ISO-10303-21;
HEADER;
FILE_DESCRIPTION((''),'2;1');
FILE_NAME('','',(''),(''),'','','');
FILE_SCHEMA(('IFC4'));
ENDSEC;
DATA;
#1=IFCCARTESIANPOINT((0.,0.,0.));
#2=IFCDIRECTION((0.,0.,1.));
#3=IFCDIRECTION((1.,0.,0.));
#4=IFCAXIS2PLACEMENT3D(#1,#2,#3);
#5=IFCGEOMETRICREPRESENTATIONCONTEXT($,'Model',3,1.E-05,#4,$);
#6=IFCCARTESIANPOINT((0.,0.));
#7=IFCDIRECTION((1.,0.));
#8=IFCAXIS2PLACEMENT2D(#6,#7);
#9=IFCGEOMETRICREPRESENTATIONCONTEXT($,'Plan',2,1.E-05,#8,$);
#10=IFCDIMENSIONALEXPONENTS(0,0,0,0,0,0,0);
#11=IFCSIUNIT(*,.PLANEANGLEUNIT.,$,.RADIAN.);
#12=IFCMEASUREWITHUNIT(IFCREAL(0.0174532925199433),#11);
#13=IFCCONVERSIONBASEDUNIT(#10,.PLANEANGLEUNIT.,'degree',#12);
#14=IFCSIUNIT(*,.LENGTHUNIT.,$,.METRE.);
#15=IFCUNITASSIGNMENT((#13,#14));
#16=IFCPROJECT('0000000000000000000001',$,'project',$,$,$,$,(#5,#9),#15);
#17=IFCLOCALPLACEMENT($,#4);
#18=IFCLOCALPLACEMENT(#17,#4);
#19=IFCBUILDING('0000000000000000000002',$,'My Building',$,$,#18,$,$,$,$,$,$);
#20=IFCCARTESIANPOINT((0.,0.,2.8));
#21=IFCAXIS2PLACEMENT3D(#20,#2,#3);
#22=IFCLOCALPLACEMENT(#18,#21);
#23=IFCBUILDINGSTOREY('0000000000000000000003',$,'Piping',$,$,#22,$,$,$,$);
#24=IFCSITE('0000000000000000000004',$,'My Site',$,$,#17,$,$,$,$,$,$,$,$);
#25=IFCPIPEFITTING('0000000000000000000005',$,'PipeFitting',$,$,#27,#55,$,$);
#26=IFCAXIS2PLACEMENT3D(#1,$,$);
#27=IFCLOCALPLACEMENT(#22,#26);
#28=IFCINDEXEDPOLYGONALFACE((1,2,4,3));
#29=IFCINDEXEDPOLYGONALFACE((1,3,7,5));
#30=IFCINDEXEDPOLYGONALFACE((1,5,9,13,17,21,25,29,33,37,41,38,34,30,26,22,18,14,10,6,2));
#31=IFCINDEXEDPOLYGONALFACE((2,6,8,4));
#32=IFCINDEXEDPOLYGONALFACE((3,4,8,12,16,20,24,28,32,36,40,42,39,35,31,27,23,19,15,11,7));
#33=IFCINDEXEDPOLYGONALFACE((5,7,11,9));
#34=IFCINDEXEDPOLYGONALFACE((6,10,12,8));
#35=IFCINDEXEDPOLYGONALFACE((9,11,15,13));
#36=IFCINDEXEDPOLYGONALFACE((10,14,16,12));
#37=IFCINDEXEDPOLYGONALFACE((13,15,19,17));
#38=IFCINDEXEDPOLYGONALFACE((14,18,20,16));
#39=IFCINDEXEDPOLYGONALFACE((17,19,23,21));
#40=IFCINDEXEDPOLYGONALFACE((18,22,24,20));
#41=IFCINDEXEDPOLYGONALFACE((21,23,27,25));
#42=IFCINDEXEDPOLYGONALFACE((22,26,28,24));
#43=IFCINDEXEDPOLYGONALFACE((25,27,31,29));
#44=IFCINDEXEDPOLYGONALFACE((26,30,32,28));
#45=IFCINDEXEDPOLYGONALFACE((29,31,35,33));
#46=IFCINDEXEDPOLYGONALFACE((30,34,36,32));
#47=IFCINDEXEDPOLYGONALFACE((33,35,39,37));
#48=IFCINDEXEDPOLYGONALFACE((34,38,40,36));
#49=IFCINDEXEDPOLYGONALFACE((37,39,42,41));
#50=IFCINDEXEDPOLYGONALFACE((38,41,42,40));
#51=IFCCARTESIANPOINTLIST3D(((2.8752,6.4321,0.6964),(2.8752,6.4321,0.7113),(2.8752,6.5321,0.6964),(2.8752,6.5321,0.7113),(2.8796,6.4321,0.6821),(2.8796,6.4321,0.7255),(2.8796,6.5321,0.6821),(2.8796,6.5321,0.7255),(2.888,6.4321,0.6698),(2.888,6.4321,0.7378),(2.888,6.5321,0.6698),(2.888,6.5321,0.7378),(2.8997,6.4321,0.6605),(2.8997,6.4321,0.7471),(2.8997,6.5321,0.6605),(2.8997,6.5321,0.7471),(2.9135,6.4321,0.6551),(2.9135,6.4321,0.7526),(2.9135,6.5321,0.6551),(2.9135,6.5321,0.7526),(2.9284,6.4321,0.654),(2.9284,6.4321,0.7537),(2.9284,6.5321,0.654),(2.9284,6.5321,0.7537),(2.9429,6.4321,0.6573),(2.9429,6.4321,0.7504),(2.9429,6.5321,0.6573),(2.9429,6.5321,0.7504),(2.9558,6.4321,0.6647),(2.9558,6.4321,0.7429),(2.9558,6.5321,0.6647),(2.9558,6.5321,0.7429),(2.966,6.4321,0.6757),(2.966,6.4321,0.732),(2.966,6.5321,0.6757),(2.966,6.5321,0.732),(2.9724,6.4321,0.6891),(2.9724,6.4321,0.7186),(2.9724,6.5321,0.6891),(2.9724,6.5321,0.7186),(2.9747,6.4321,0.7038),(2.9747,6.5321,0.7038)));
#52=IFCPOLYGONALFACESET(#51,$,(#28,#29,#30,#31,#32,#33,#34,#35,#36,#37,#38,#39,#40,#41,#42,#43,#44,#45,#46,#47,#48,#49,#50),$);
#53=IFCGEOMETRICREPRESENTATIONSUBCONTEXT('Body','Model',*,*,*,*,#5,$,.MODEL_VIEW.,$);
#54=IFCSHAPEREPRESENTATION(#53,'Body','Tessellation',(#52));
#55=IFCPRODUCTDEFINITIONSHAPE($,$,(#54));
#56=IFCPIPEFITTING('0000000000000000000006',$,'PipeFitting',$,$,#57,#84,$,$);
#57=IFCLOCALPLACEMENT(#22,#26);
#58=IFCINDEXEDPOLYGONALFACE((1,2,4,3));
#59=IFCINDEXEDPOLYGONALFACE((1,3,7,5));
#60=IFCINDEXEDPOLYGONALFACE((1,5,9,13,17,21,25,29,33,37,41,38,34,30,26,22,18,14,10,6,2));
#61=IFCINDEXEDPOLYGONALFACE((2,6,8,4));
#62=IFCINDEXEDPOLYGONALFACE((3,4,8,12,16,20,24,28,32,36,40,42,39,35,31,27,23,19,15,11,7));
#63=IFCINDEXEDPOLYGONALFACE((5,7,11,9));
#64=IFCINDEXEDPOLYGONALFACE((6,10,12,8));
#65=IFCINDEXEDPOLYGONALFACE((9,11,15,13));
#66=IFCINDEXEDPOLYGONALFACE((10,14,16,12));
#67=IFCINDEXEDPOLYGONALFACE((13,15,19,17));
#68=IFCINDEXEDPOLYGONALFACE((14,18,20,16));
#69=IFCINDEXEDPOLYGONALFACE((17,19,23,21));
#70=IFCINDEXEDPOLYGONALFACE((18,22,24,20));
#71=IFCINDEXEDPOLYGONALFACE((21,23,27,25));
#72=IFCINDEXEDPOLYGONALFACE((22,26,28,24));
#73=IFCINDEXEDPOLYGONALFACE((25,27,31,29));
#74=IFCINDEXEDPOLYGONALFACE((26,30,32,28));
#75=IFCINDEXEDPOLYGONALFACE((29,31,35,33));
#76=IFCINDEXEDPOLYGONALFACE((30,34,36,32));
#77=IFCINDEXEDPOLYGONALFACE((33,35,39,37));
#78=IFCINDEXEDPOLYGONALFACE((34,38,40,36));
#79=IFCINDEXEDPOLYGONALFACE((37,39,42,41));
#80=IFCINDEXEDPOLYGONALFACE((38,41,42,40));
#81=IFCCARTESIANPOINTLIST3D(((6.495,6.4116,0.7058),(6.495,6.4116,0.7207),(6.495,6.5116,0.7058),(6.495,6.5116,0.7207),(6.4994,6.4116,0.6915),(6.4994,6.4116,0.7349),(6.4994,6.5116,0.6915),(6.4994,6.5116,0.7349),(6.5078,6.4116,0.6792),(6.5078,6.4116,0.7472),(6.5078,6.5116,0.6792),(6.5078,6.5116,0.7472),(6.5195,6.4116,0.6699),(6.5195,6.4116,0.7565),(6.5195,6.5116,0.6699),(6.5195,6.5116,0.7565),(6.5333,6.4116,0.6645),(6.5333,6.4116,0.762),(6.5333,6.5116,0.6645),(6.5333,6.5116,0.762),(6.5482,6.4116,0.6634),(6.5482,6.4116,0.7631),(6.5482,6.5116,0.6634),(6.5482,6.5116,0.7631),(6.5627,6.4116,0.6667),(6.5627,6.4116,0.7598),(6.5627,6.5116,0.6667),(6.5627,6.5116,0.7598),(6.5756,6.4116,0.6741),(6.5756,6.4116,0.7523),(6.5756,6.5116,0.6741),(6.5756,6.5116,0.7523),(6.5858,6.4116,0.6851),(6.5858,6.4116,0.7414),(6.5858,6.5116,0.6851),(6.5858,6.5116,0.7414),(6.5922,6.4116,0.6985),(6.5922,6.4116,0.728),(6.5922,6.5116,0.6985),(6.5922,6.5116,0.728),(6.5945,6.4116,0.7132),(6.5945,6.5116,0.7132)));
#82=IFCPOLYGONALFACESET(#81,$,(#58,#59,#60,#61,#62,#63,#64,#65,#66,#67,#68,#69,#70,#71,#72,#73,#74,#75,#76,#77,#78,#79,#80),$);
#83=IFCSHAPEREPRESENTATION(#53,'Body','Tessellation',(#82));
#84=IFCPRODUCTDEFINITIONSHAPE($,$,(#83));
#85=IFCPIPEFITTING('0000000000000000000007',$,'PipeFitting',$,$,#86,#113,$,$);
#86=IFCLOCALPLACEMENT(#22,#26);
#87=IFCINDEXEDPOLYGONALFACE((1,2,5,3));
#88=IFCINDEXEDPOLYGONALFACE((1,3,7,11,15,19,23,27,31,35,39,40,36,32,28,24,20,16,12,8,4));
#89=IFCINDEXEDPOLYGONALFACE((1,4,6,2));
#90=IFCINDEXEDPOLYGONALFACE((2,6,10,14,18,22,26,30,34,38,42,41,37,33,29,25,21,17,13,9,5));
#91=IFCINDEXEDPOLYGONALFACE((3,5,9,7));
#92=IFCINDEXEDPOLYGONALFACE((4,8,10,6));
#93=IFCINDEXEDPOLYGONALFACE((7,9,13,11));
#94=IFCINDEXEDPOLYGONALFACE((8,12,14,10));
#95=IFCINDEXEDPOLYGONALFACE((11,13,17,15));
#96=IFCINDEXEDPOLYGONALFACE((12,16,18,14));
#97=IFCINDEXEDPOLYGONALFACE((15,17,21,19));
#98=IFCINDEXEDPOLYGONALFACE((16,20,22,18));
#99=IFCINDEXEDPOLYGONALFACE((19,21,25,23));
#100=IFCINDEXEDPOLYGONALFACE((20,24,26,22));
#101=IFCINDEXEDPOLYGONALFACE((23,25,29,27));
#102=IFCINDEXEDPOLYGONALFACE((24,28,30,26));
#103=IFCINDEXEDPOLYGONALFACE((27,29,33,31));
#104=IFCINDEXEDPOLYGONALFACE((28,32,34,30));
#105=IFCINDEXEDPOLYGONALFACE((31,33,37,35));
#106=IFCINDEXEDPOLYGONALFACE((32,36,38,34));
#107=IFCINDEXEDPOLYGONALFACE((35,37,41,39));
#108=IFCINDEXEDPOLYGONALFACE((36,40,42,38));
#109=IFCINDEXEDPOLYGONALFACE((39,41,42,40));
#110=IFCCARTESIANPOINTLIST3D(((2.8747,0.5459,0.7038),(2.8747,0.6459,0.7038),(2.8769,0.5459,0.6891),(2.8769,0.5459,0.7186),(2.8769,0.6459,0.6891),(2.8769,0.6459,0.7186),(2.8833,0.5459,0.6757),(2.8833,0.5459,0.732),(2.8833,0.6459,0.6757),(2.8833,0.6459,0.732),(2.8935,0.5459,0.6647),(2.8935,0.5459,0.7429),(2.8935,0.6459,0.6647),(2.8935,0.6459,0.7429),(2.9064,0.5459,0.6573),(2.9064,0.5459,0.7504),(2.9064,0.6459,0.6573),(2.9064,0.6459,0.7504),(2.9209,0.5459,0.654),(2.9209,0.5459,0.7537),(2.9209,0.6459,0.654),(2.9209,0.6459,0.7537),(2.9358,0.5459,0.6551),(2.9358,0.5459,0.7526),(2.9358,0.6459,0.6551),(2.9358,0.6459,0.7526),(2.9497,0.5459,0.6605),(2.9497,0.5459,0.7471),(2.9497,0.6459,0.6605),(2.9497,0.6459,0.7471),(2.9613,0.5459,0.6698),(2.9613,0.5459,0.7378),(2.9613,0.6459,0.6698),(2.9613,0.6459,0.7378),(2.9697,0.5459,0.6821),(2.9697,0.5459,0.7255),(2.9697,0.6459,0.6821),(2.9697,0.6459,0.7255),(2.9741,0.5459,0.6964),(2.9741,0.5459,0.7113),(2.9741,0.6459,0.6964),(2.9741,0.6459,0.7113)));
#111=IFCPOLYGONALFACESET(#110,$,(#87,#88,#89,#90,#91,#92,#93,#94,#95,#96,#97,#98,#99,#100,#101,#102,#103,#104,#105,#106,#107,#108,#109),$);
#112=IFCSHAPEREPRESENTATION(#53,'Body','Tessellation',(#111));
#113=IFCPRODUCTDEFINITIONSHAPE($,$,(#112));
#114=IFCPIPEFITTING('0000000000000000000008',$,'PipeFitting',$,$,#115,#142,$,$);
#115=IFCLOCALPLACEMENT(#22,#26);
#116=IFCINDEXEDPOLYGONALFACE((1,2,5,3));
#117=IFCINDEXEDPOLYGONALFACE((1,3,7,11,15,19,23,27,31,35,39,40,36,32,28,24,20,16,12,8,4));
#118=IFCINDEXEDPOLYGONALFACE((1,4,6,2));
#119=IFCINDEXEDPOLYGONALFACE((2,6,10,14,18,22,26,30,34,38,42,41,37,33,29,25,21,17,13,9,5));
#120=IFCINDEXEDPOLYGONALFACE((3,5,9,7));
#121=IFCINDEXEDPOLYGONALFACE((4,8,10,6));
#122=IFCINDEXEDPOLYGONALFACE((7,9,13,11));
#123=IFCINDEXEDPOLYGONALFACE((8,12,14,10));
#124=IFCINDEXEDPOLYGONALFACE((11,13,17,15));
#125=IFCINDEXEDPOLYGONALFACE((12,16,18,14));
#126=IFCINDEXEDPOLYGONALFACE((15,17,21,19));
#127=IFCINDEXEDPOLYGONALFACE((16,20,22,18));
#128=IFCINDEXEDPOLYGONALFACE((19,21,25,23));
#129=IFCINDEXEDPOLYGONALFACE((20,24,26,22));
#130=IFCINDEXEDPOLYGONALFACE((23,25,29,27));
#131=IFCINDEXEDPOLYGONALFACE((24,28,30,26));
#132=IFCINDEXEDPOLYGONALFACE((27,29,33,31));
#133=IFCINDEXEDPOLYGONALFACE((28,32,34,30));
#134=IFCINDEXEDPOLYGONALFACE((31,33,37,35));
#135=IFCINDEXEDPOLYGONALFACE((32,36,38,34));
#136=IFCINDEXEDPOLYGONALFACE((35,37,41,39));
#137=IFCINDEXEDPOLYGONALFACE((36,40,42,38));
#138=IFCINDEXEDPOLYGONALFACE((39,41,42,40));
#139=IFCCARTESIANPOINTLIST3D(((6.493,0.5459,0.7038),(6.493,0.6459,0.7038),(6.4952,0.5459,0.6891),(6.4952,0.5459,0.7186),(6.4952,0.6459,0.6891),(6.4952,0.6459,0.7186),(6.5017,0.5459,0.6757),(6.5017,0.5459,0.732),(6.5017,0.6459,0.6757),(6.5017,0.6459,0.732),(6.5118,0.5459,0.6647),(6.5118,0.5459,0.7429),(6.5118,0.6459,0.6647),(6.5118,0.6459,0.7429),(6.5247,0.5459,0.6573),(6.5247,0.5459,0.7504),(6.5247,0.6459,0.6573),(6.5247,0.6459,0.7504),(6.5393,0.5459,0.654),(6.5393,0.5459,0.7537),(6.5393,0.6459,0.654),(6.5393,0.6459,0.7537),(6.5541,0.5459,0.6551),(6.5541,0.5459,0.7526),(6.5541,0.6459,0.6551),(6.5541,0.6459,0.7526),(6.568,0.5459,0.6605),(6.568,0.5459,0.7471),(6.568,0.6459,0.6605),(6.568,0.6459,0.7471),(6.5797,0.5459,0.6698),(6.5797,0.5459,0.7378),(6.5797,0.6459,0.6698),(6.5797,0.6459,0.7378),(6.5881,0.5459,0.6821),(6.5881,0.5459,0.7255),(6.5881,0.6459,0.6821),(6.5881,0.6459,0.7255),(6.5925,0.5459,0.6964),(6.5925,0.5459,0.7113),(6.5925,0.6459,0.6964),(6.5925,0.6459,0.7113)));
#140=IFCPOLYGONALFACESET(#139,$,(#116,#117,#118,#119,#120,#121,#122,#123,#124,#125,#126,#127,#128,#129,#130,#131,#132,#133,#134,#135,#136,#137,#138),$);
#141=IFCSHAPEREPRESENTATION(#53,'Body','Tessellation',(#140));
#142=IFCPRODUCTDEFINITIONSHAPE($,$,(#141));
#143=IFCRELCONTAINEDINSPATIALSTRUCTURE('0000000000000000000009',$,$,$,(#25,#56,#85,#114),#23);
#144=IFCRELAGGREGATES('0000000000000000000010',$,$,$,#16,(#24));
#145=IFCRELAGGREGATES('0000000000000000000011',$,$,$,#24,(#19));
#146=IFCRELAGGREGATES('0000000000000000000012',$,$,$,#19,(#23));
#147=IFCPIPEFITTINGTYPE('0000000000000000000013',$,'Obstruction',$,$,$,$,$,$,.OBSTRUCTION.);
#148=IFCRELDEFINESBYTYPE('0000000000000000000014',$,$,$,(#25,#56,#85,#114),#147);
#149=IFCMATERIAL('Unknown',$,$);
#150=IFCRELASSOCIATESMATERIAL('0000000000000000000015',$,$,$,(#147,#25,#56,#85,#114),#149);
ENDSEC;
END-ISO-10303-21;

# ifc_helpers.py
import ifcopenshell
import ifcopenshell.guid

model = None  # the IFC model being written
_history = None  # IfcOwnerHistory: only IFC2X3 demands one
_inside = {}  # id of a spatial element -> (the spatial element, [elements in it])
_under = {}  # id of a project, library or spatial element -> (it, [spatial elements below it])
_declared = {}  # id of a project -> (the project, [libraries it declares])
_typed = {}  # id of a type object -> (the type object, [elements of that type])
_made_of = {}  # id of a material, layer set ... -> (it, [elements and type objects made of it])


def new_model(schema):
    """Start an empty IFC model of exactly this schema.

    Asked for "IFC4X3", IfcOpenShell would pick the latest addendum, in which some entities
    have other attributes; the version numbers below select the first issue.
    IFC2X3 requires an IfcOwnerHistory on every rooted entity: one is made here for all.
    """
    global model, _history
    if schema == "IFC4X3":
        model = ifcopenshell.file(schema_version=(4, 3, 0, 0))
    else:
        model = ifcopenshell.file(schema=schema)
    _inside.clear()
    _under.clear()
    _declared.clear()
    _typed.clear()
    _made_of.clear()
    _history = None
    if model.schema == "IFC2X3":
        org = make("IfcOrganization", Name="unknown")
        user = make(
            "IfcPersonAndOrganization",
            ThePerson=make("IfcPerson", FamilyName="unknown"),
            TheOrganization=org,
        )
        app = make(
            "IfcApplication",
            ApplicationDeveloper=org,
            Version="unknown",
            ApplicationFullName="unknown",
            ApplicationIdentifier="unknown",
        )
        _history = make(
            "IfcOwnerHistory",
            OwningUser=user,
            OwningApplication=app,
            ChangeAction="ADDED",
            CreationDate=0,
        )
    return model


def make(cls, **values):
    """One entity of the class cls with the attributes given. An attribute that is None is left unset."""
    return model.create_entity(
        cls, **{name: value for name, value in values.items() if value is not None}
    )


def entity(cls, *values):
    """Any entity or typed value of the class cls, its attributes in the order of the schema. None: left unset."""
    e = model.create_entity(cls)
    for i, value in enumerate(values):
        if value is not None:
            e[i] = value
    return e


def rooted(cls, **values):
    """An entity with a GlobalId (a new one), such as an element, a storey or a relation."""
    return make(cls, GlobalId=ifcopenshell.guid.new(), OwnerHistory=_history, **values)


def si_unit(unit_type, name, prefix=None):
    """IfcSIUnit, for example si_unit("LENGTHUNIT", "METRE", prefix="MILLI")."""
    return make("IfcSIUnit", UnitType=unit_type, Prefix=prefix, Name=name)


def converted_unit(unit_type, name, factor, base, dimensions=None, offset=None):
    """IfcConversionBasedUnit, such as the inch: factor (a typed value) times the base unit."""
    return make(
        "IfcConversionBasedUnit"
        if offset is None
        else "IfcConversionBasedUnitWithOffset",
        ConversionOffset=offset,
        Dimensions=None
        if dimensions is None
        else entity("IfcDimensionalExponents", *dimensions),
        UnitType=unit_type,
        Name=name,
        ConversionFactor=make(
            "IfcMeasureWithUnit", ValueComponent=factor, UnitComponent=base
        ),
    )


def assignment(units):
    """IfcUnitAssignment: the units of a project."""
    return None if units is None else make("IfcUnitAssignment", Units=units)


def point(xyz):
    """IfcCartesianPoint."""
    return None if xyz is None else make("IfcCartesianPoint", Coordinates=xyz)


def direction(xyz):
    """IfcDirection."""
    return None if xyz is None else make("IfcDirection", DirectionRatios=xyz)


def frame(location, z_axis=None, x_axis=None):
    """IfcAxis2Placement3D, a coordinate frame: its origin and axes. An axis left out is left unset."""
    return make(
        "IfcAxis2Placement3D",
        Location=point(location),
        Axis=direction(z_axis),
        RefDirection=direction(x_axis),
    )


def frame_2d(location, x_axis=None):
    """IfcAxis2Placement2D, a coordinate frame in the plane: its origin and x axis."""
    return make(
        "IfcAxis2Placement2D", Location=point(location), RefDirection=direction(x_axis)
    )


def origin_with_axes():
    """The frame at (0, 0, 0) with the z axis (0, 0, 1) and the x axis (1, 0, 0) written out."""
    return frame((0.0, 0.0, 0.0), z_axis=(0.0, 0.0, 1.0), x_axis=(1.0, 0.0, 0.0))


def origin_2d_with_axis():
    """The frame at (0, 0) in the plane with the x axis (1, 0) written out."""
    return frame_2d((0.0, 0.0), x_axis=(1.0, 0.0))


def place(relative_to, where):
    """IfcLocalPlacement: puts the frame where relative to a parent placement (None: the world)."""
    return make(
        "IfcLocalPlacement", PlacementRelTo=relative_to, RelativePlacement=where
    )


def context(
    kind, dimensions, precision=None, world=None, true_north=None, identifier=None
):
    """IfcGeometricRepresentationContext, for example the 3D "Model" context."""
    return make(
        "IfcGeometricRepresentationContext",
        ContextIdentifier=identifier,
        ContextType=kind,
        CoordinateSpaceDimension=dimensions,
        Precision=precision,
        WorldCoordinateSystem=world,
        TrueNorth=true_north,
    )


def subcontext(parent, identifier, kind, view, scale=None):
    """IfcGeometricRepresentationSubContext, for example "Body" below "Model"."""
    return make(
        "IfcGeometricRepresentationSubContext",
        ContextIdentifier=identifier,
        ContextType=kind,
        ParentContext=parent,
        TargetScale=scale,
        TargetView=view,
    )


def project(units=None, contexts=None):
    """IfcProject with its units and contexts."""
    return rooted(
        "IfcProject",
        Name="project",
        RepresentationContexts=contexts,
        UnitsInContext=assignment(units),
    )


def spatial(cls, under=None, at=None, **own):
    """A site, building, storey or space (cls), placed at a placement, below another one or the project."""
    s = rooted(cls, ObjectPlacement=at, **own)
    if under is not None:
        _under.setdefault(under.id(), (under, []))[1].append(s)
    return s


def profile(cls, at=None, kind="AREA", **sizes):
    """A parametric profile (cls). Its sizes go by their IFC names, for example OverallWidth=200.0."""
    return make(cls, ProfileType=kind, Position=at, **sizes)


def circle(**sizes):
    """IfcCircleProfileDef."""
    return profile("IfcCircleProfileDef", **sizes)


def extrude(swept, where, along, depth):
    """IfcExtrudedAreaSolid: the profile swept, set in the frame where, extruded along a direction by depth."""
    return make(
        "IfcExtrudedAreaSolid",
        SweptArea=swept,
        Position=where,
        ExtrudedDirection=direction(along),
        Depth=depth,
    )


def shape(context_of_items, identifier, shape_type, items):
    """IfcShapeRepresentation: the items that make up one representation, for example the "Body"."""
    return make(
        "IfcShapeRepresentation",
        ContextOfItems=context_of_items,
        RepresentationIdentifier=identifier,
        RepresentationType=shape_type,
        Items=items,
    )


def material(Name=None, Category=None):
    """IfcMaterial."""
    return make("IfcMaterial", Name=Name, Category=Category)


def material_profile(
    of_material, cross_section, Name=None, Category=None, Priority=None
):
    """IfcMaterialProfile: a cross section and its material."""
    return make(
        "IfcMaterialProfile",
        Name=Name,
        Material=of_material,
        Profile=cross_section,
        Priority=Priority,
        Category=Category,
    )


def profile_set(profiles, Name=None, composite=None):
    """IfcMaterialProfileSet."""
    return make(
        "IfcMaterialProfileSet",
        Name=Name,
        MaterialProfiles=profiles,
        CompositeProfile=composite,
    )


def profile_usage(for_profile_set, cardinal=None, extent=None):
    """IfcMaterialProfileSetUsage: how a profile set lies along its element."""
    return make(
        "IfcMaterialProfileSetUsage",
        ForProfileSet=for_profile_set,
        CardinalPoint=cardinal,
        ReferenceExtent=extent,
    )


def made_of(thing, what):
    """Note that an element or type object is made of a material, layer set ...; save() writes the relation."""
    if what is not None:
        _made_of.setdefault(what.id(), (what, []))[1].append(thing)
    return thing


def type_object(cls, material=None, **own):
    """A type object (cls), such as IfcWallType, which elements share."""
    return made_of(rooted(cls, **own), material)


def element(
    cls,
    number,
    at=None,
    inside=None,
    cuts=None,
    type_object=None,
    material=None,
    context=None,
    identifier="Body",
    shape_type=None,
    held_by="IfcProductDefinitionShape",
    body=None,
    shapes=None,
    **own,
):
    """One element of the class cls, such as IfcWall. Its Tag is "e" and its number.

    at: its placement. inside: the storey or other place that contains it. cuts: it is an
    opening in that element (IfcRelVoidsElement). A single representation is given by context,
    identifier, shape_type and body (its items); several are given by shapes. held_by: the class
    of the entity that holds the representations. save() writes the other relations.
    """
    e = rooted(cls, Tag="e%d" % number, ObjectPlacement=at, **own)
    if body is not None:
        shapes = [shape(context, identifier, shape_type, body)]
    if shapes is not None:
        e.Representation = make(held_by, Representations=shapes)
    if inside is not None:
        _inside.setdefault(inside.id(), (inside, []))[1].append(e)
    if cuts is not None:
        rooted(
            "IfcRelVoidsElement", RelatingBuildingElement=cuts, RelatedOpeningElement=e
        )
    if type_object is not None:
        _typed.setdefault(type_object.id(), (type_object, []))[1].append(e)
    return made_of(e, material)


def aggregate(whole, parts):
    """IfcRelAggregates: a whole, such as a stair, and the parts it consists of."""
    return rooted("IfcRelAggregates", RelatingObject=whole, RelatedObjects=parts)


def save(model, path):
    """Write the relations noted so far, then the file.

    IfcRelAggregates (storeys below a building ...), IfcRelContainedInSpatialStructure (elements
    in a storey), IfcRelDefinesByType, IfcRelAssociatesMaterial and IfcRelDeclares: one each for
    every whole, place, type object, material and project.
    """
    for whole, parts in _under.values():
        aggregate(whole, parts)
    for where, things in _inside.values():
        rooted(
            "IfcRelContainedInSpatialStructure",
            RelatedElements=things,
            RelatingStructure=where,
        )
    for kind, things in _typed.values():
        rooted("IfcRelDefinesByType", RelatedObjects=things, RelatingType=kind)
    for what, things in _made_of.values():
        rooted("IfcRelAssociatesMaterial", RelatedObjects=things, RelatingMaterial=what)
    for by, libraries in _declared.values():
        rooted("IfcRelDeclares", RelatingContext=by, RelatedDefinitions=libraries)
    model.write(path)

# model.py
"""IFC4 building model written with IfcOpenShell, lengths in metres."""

from ifc_helpers import new_model, entity, si_unit, converted_unit, frame, origin_with_axes, origin_2d_with_axis, place, context, subcontext, project, spatial, circle, extrude, material, material_profile, profile_set, profile_usage, type_object, element, save


model = new_model("IFC4")

# Units and contexts
model_context = context("Model", 3, precision=1e-05, world=origin_with_axes())
plan_context = context("Plan", 2, precision=1e-05, world=origin_2d_with_axis())
body_context = subcontext(model_context, "Body", "Model", "MODEL_VIEW")
ifc_project = project(units=[converted_unit("PLANEANGLEUNIT", "degree", entity("IfcReal", 0.0174532925199433), si_unit("PLANEANGLEUNIT", "RADIAN"), dimensions=[0, 0, 0, 0, 0, 0, 0]), si_unit("LENGTHUNIT", "METRE")], contexts=[model_context, plan_context])

# Site, building, storey
site_placement = place(None, origin_with_axes())
site = spatial("IfcSite", under=ifc_project, at=site_placement, Name="My Site")
building_placement = place(site_placement, origin_with_axes())
building = spatial("IfcBuilding", under=site, at=building_placement, Name="My Building")
storey_placement = place(building_placement, frame((0.0, 0.0, 2.8), z_axis=(0.0, 0.0, 1.0), x_axis=(1.0, 0.0, 0.0)))
storey = spatial("IfcBuildingStorey", under=building, at=storey_placement, Name="Piping")

# Shared definitions
ifc_material = material(Name="Unknown")

# Pipe fittings
ifc_material_profile_1 = material_profile(ifc_material, circle(Radius=0.05))
ifc_profile_set_1 = profile_set([ifc_material_profile_1])
ifc_profile_usage_1 = profile_usage(ifc_profile_set_1, cardinal=5)
pipe_fitting_type_1 = type_object("IfcPipeFittingType", Name="Obstruction", PredefinedType="OBSTRUCTION", material=ifc_profile_set_1)
pipe_fitting_1_placement = place(storey_placement, frame((2.9247, 6.5321, 0.7038), z_axis=(0.0, -1.0, 0.0), x_axis=(1.0, 0.0, 0.0)))
element("IfcPipeFitting", 1, at=pipe_fitting_1_placement, inside=storey, type_object=pipe_fitting_type_1, material=ifc_profile_usage_1, Name="PipeFitting", context=body_context, shape_type="SweptSolid", body=[
    extrude(circle(Radius=0.05), origin_with_axes(), (0.0, 0.0, 1.0), 0.1),
])
ifc_profile_usage_2 = profile_usage(ifc_profile_set_1, cardinal=5)
pipe_fitting_2_placement = place(storey_placement, frame((6.5445, 6.5116, 0.7132), z_axis=(0.0, -1.0, 0.0), x_axis=(1.0, 0.0, 0.0)))
element("IfcPipeFitting", 2, at=pipe_fitting_2_placement, inside=storey, type_object=pipe_fitting_type_1, material=ifc_profile_usage_2, Name="PipeFitting", context=body_context, shape_type="SweptSolid", body=[
    extrude(circle(Radius=0.05), origin_with_axes(), (0.0, 0.0, 1.0), 0.1),
])
ifc_profile_usage_3 = profile_usage(ifc_profile_set_1, cardinal=5)
pipe_fitting_3_placement = place(storey_placement, frame((2.9247, 0.5459, 0.7038), z_axis=(0.0, 1.0, 0.0), x_axis=(-1.0, 0.0, 0.0)))
element("IfcPipeFitting", 3, at=pipe_fitting_3_placement, inside=storey, type_object=pipe_fitting_type_1, material=ifc_profile_usage_3, Name="PipeFitting", context=body_context, shape_type="SweptSolid", body=[
    extrude(circle(Radius=0.05), origin_with_axes(), (0.0, 0.0, 1.0), 0.1),
])
ifc_profile_usage_4 = profile_usage(ifc_profile_set_1, cardinal=5)
pipe_fitting_4_placement = place(storey_placement, frame((6.543, 0.5459, 0.7038), z_axis=(0.0, 1.0, 0.0), x_axis=(-1.0, 0.0, 0.0)))
element("IfcPipeFitting", 4, at=pipe_fitting_4_placement, inside=storey, type_object=pipe_fitting_type_1, material=ifc_profile_usage_4, Name="PipeFitting", context=body_context, shape_type="SweptSolid", body=[
    extrude(circle(Radius=0.05), origin_with_axes(), (0.0, 0.0, 1.0), 0.1),
])

save(model, "model.ifc")
